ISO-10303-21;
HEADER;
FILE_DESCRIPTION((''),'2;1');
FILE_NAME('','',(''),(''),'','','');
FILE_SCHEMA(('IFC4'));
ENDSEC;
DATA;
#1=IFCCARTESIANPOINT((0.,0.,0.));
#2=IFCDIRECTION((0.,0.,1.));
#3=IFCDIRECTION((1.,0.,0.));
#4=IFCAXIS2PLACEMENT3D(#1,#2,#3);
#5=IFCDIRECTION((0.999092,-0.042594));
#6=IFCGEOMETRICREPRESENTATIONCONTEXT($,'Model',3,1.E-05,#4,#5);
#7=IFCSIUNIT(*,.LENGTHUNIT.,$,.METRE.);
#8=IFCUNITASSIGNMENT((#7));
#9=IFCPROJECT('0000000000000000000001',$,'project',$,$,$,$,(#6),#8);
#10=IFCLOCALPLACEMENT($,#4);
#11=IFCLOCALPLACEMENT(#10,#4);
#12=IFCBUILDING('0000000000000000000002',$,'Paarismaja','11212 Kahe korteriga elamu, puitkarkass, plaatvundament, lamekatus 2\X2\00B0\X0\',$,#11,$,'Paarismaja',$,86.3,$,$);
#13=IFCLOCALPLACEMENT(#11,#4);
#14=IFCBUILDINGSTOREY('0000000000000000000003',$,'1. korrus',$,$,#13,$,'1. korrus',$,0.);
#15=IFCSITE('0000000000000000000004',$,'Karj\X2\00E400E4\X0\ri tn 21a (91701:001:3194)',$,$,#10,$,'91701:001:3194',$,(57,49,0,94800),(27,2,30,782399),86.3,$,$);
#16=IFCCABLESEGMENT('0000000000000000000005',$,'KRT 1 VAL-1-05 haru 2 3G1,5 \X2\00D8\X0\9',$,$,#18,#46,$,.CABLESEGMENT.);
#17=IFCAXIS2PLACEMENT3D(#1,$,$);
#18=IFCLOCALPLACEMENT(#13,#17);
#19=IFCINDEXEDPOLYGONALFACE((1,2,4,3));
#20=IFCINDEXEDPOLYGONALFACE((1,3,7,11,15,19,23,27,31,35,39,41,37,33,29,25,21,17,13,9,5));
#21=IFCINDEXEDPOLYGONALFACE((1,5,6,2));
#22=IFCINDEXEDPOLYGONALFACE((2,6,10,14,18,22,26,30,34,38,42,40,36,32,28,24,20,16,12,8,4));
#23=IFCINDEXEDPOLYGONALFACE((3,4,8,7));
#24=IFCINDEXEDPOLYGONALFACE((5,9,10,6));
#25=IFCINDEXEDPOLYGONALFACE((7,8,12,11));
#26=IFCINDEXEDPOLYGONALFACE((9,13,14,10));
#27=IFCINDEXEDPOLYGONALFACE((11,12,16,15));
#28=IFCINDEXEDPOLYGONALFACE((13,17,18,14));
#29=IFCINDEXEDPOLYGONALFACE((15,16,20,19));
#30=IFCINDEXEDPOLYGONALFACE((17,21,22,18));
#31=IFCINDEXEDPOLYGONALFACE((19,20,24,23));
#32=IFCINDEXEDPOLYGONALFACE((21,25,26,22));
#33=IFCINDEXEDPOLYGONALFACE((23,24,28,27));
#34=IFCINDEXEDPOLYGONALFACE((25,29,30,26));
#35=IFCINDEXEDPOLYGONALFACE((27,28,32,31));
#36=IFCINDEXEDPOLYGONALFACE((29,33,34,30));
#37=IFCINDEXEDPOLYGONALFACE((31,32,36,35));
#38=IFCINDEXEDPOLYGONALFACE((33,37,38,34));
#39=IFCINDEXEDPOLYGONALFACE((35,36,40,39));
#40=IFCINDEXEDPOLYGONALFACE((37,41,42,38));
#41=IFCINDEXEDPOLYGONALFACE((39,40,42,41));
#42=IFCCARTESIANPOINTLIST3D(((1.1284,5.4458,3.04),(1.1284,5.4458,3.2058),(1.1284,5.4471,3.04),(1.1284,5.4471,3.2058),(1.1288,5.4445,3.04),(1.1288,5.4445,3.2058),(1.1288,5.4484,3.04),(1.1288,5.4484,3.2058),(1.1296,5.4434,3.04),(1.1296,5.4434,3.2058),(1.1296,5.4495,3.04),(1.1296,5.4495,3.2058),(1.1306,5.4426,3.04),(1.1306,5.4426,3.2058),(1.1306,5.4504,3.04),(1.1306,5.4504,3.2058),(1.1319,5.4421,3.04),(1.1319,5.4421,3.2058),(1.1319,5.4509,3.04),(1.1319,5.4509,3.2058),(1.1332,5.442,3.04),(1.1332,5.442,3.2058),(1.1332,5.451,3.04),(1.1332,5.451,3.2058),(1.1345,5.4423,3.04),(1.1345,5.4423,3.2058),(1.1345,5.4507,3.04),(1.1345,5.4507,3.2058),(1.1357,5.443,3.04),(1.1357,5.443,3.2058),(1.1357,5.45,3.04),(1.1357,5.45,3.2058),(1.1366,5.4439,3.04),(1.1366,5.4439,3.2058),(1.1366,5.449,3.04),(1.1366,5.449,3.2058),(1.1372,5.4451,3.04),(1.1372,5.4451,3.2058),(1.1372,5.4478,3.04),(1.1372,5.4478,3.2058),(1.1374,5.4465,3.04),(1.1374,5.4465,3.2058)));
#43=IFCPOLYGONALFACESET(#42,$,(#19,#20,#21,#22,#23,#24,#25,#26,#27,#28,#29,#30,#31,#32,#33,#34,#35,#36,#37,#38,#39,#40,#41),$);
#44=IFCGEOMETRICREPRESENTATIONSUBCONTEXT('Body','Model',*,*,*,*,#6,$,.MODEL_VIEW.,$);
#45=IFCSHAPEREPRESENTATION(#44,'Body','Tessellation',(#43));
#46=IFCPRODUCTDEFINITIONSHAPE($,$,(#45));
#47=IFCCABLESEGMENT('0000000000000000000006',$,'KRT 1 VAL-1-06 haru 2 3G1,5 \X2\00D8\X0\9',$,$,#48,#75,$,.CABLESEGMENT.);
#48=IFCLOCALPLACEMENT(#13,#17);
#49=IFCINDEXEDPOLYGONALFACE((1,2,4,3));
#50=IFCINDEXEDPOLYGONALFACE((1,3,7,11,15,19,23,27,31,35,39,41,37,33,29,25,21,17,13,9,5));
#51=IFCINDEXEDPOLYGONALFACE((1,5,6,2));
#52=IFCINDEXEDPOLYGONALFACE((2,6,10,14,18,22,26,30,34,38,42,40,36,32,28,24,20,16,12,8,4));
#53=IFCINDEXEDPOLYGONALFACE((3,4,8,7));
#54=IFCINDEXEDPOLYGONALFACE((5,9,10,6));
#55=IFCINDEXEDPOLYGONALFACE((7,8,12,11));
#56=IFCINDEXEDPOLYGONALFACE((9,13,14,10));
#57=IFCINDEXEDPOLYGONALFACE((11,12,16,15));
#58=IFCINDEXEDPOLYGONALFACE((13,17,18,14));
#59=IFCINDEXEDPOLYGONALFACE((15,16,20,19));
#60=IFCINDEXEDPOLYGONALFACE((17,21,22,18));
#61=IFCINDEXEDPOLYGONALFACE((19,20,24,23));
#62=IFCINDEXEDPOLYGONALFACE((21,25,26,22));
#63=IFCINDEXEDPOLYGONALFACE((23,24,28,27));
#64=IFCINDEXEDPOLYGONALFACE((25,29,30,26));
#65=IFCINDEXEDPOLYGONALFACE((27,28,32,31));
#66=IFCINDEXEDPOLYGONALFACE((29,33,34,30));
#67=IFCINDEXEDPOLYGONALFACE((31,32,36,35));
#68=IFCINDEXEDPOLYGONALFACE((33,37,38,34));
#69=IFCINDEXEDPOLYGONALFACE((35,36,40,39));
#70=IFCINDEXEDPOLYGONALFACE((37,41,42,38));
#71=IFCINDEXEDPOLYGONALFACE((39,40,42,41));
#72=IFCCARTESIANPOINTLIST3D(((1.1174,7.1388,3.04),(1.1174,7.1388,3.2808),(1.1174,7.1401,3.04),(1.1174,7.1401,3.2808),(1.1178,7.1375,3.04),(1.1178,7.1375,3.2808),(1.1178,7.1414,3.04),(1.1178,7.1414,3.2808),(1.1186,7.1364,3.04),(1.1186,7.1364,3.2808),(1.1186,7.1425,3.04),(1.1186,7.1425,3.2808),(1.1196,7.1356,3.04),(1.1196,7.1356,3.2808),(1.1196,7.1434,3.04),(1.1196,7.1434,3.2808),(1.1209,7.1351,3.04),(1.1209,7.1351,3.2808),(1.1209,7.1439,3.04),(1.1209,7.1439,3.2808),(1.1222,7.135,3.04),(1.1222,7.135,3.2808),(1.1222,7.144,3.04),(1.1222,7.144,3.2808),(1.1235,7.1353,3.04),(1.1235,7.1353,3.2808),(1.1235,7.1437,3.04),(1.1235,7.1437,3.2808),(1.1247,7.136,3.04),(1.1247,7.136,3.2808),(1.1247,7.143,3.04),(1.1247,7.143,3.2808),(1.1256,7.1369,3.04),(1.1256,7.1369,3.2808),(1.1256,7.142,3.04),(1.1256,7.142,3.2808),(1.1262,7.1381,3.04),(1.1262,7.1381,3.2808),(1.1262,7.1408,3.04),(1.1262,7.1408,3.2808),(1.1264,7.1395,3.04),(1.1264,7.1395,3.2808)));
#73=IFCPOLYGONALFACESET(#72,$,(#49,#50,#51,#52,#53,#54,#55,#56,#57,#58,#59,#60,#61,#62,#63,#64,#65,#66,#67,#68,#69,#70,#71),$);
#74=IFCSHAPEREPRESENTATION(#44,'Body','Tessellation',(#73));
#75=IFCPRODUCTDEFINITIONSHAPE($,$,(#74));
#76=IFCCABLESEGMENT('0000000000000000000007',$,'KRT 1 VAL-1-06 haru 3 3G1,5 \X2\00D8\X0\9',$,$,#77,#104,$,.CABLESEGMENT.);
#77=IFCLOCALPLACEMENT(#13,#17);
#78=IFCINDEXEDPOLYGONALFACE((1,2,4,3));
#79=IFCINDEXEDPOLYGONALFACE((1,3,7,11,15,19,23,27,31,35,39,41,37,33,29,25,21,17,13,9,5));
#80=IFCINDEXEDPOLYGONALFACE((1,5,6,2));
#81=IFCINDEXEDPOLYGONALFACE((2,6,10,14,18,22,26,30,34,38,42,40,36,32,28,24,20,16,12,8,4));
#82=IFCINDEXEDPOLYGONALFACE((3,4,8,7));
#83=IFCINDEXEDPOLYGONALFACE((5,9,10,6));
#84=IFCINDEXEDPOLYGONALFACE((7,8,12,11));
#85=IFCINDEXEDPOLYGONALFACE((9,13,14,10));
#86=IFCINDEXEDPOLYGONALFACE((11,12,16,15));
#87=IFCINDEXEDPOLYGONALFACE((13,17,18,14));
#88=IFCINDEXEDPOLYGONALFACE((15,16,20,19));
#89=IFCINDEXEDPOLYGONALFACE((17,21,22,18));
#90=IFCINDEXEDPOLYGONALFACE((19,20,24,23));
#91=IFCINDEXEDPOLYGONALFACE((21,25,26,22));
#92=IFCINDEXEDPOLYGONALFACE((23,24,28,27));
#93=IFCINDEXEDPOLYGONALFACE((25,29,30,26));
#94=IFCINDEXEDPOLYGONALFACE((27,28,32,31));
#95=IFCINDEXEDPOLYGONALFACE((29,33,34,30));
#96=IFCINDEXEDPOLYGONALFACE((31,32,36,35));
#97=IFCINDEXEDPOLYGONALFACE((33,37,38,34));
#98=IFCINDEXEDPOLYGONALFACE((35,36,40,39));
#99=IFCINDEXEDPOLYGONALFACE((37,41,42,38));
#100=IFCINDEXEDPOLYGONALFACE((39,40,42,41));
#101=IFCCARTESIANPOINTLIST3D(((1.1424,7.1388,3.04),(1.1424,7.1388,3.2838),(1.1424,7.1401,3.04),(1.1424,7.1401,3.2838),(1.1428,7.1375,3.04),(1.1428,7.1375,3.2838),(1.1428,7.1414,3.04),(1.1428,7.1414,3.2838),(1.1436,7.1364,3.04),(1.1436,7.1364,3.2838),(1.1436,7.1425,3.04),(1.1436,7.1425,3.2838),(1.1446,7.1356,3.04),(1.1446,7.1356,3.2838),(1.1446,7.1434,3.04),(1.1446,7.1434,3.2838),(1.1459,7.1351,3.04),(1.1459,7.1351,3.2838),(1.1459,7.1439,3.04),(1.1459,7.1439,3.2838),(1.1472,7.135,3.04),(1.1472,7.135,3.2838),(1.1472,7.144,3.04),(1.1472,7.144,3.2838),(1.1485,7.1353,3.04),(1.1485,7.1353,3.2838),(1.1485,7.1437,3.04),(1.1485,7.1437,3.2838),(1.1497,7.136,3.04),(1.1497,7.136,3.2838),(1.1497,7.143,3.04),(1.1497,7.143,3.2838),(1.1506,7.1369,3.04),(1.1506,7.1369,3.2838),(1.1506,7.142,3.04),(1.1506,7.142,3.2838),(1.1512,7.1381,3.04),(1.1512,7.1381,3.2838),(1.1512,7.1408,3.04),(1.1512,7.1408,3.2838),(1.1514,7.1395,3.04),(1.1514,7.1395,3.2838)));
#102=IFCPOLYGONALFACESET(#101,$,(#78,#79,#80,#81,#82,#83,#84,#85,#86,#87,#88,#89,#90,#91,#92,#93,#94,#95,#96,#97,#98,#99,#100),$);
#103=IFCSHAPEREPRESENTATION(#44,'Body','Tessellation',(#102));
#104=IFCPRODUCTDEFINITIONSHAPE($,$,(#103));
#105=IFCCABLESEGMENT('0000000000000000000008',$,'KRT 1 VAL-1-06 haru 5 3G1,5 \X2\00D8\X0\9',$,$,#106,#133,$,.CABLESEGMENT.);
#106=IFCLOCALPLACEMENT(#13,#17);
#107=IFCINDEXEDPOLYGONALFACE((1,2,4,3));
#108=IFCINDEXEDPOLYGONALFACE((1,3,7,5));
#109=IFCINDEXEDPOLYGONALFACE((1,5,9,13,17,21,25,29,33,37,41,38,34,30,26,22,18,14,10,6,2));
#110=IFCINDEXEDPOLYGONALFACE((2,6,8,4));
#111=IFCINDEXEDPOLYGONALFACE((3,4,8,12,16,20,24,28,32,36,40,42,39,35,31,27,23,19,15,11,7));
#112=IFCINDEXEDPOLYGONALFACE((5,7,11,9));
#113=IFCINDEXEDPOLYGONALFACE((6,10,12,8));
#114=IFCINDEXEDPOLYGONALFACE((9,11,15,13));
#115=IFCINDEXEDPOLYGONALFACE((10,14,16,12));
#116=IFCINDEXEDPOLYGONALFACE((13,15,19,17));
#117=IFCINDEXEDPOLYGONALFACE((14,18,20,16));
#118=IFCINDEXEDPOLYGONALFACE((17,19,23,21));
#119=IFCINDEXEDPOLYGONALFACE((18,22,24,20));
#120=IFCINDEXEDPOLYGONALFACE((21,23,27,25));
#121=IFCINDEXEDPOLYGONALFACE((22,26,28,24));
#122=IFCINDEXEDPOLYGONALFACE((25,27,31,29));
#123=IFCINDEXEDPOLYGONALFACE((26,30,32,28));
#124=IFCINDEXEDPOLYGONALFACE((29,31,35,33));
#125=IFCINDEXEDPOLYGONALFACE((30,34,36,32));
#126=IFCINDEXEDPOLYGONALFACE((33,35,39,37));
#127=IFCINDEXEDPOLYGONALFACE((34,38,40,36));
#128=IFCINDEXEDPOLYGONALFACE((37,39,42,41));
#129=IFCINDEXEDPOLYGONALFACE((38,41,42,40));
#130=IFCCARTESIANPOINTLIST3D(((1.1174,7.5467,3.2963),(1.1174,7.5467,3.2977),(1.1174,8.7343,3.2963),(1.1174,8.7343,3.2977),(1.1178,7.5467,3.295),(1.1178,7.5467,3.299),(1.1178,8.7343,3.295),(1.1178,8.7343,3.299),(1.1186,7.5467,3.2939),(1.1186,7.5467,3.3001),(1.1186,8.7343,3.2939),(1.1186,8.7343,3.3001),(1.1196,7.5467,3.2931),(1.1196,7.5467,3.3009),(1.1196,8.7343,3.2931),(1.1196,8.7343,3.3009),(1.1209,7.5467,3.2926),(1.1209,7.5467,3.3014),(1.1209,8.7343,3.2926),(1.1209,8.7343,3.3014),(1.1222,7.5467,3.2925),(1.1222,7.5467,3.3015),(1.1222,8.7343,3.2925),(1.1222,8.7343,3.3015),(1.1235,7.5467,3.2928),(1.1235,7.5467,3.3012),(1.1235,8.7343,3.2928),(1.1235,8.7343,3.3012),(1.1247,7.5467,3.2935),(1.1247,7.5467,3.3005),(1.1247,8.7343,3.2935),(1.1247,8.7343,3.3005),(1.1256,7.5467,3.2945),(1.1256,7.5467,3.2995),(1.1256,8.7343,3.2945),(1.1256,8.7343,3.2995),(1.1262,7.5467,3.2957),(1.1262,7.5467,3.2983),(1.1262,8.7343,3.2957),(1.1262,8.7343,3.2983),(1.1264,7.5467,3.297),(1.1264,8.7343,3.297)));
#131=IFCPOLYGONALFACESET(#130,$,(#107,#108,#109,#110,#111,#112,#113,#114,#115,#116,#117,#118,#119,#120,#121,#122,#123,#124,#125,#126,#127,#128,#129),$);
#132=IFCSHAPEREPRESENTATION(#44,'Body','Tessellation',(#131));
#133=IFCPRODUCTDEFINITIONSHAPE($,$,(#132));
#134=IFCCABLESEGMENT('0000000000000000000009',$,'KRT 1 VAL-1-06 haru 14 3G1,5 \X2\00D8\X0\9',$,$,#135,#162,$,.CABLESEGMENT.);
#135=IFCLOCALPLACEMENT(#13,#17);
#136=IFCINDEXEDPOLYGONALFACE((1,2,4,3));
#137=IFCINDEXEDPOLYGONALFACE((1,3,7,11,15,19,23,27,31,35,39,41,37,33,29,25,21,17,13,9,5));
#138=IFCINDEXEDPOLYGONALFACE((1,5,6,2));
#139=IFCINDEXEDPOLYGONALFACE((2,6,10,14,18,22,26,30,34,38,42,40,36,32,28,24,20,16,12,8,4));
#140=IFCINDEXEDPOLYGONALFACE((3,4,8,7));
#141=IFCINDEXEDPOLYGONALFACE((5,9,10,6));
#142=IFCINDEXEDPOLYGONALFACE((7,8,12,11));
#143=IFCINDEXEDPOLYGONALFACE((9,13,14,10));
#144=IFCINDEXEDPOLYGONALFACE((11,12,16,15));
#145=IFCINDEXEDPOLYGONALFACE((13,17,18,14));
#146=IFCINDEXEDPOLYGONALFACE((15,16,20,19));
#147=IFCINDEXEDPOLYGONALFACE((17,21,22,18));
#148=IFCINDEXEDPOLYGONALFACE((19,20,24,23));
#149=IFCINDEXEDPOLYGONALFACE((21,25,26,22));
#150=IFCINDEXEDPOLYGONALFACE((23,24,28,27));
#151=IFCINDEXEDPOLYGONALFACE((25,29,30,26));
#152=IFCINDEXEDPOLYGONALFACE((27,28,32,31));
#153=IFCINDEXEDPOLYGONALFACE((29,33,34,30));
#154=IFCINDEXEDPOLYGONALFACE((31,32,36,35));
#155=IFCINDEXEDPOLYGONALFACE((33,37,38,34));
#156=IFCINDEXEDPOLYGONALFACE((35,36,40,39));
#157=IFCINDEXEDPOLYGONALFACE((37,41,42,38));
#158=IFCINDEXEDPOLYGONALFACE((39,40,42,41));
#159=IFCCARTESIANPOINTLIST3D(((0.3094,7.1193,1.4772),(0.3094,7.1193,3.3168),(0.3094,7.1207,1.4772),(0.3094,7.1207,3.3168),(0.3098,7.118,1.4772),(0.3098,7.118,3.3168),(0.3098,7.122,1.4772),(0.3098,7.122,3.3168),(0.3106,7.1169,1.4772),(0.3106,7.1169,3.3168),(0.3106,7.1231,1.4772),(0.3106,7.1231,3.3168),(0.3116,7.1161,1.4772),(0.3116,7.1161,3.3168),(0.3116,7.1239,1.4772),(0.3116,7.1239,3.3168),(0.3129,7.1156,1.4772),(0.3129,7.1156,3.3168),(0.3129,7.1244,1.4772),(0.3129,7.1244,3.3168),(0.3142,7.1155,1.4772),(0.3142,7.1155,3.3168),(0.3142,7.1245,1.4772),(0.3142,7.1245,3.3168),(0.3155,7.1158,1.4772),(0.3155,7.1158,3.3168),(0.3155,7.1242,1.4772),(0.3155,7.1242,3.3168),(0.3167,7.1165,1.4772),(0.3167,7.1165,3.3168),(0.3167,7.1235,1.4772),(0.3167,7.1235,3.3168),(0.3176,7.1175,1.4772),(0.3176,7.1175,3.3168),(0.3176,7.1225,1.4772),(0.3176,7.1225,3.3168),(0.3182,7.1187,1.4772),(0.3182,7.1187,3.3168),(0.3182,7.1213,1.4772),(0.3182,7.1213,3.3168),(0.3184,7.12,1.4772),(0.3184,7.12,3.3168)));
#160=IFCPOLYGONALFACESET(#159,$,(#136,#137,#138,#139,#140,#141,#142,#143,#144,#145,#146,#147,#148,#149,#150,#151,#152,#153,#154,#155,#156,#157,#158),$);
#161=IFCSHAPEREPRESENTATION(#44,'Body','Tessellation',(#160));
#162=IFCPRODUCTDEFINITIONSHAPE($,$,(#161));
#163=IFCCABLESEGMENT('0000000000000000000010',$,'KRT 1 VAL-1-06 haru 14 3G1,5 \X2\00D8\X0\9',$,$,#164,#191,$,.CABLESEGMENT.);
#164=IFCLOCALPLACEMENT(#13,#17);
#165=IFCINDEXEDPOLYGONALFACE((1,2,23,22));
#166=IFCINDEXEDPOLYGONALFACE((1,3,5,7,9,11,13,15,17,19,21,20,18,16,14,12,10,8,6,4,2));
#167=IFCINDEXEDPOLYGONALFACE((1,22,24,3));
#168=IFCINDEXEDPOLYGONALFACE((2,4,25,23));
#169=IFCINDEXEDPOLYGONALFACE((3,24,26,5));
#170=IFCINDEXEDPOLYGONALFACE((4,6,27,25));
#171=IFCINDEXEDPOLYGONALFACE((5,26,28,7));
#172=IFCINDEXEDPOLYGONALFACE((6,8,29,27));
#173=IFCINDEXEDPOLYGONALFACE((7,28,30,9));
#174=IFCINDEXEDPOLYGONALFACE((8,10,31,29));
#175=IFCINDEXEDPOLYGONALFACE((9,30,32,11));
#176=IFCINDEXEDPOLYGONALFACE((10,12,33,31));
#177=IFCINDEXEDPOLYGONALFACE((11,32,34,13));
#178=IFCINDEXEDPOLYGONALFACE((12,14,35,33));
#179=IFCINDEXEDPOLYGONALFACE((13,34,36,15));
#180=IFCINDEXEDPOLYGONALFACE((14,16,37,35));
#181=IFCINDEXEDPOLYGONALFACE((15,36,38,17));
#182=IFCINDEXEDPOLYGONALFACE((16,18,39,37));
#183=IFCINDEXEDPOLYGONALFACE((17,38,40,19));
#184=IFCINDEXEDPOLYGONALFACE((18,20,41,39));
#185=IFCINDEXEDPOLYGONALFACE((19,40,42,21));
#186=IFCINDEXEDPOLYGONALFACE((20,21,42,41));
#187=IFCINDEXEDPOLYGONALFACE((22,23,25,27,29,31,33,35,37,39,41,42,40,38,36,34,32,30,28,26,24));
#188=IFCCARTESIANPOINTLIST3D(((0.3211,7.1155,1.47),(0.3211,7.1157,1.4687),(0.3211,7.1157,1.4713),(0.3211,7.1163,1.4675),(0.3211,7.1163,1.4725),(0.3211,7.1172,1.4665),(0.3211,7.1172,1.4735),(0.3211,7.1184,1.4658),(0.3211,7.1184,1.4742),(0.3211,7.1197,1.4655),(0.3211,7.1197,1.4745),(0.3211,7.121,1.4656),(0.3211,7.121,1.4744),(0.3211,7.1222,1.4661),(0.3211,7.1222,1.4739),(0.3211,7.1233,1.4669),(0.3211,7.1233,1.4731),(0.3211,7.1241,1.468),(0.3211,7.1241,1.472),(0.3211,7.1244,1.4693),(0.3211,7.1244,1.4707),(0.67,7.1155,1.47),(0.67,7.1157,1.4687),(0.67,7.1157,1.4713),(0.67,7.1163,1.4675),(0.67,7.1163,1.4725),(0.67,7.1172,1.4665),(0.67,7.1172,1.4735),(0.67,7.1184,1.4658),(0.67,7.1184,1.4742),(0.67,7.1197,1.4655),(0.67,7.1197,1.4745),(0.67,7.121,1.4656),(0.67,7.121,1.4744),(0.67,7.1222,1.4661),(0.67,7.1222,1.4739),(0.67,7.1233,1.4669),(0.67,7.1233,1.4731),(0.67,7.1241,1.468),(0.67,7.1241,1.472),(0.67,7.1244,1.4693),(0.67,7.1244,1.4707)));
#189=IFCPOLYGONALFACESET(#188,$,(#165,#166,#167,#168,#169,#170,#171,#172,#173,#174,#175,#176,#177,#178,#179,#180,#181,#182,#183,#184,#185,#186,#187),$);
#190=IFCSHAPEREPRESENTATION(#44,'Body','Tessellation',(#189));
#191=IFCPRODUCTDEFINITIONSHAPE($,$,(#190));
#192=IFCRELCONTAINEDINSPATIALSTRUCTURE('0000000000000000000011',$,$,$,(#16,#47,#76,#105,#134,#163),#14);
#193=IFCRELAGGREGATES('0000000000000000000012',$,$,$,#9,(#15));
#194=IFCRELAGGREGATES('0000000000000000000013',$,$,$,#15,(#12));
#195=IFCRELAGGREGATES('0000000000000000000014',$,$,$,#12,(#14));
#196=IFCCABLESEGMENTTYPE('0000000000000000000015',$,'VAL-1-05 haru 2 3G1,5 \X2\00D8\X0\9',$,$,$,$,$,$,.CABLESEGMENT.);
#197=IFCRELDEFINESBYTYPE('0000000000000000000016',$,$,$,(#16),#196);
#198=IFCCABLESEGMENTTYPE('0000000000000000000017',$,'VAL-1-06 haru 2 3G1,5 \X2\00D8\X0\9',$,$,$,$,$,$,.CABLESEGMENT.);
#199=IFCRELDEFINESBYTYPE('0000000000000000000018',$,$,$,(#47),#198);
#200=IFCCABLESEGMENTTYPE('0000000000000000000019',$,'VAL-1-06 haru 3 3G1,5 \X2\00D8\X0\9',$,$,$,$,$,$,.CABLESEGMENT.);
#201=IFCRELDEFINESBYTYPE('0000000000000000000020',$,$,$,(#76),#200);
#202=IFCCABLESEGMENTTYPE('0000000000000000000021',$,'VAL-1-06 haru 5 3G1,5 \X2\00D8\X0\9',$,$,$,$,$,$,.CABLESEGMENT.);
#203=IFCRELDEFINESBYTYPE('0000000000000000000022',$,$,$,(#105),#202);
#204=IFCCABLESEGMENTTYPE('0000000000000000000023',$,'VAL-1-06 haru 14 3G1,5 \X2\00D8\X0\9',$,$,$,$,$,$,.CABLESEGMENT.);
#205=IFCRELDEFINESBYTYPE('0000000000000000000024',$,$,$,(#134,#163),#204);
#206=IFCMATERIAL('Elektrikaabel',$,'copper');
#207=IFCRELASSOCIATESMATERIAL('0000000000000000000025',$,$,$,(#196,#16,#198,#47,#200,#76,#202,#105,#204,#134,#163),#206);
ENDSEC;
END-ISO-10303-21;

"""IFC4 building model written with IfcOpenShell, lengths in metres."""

from ifc_helpers import new_model, si_unit, direction, frame, origin_with_axes, place, context, subcontext, project, spatial, circle, extrude, material, type_object, element, save


model = new_model("IFC4")

# Units and contexts
model_context = context("Model", 3, precision=1e-05, world=origin_with_axes(), true_north=direction((0.999092, -0.042594)))
body_context = subcontext(model_context, "Body", "Model", "MODEL_VIEW")
ifc_project = project(units=[si_unit("LENGTHUNIT", "METRE")], contexts=[model_context])

# Site, building, storey
site_placement = place(None, origin_with_axes())
site = spatial("IfcSite", under=ifc_project, at=site_placement, Name="Karjääri tn 21a (91701:001:3194)", LongName="91701:001:3194", RefLatitude=(57, 49, 0, 94800), RefLongitude=(27, 2, 30, 782399), RefElevation=86.3)
building_placement = place(site_placement, origin_with_axes())
building = spatial("IfcBuilding", under=site, at=building_placement, Name="Paarismaja", Description="11212 Kahe korteriga elamu, puitkarkass, plaatvundament, lamekatus 2°", LongName="Paarismaja", ElevationOfRefHeight=86.3)
storey_placement = place(building_placement, origin_with_axes())
storey = spatial("IfcBuildingStorey", under=building, at=storey_placement, Name="1. korrus", LongName="1. korrus", Elevation=0.0)

# Shared definitions
ifc_material_1 = material(Name="Elektrikaabel", Category="copper")

# Cable segments
cable_segment_type_1 = type_object("IfcCableSegmentType", Name="VAL-1-05 haru 2 3G1,5 Ø9", PredefinedType="CABLESEGMENT", material=ifc_material_1)
cable_segment_1_placement = place(storey_placement, frame((1.1329, 5.4465, 3.2058), z_axis=(0.0, 0.0, -1.0), x_axis=(1.0, 0.0, 0.0)))
element("IfcCableSegment", 1, at=cable_segment_1_placement, inside=storey, type_object=cable_segment_type_1, material=ifc_material_1, Name="KRT 1 VAL-1-05 haru 2 3G1,5 Ø9", PredefinedType="CABLESEGMENT", context=body_context, shape_type="SweptSolid", body=[
    extrude(circle(Radius=0.0045), origin_with_axes(), (0.0, 0.0, 1.0), 0.1658),
])
cable_segment_type_2 = type_object("IfcCableSegmentType", Name="VAL-1-06 haru 2 3G1,5 Ø9", PredefinedType="CABLESEGMENT", material=ifc_material_1)
cable_segment_2_placement = place(storey_placement, frame((1.1219, 7.1395, 3.2808), z_axis=(0.0, 0.0, -1.0), x_axis=(1.0, 0.0, 0.0)))
element("IfcCableSegment", 2, at=cable_segment_2_placement, inside=storey, type_object=cable_segment_type_2, material=ifc_material_1, Name="KRT 1 VAL-1-06 haru 2 3G1,5 Ø9", PredefinedType="CABLESEGMENT", context=body_context, shape_type="SweptSolid", body=[
    extrude(circle(Radius=0.0045), origin_with_axes(), (0.0, 0.0, 1.0), 0.2408),
])
cable_segment_type_3 = type_object("IfcCableSegmentType", Name="VAL-1-06 haru 3 3G1,5 Ø9", PredefinedType="CABLESEGMENT", material=ifc_material_1)
cable_segment_3_placement = place(storey_placement, frame((1.1469, 7.1395, 3.04), z_axis=(0.0, 0.0, 1.0), x_axis=(1.0, 0.0, 0.0)))
element("IfcCableSegment", 3, at=cable_segment_3_placement, inside=storey, type_object=cable_segment_type_3, material=ifc_material_1, Name="KRT 1 VAL-1-06 haru 3 3G1,5 Ø9", PredefinedType="CABLESEGMENT", context=body_context, shape_type="SweptSolid", body=[
    extrude(circle(Radius=0.0045), origin_with_axes(), (0.0, 0.0, 1.0), 0.2438),
])
cable_segment_type_4 = type_object("IfcCableSegmentType", Name="VAL-1-06 haru 5 3G1,5 Ø9", PredefinedType="CABLESEGMENT", material=ifc_material_1)
cable_segment_4_placement = place(storey_placement, frame((1.1219, 7.5467, 3.297), z_axis=(0.0, 1.0, 0.0), x_axis=(1.0, 0.0, 0.0)))
element("IfcCableSegment", 4, at=cable_segment_4_placement, inside=storey, type_object=cable_segment_type_4, material=ifc_material_1, Name="KRT 1 VAL-1-06 haru 5 3G1,5 Ø9", PredefinedType="CABLESEGMENT", context=body_context, shape_type="SweptSolid", body=[
    extrude(circle(Radius=0.0045), origin_with_axes(), (0.0, 0.0, 1.0), 1.1876),
])
cable_segment_type_5 = type_object("IfcCableSegmentType", Name="VAL-1-06 haru 14 3G1,5 Ø9", PredefinedType="CABLESEGMENT", material=ifc_material_1)
cable_segment_5_placement = place(storey_placement, frame((0.3139, 7.12, 3.3168), z_axis=(0.0, 0.0, -1.0), x_axis=(1.0, 0.0, 0.0)))
element("IfcCableSegment", 5, at=cable_segment_5_placement, inside=storey, type_object=cable_segment_type_5, material=ifc_material_1, Name="KRT 1 VAL-1-06 haru 14 3G1,5 Ø9", PredefinedType="CABLESEGMENT", context=body_context, shape_type="SweptSolid", body=[
    extrude(circle(Radius=0.0045), origin_with_axes(), (0.0, 0.0, 1.0), 1.8396),
])
cable_segment_6_placement = place(storey_placement, frame((0.3211, 7.12, 1.47), z_axis=(1.0, 0.0, 0.0), x_axis=(0.0, -1.0, 0.0)))
element("IfcCableSegment", 6, at=cable_segment_6_placement, inside=storey, type_object=cable_segment_type_5, material=ifc_material_1, Name="KRT 1 VAL-1-06 haru 14 3G1,5 Ø9", PredefinedType="CABLESEGMENT", context=body_context, shape_type="SweptSolid", body=[
    extrude(circle(Radius=0.0045), origin_with_axes(), (0.0, 0.0, 1.0), 0.3489),
])

save(model, "model.ifc")
